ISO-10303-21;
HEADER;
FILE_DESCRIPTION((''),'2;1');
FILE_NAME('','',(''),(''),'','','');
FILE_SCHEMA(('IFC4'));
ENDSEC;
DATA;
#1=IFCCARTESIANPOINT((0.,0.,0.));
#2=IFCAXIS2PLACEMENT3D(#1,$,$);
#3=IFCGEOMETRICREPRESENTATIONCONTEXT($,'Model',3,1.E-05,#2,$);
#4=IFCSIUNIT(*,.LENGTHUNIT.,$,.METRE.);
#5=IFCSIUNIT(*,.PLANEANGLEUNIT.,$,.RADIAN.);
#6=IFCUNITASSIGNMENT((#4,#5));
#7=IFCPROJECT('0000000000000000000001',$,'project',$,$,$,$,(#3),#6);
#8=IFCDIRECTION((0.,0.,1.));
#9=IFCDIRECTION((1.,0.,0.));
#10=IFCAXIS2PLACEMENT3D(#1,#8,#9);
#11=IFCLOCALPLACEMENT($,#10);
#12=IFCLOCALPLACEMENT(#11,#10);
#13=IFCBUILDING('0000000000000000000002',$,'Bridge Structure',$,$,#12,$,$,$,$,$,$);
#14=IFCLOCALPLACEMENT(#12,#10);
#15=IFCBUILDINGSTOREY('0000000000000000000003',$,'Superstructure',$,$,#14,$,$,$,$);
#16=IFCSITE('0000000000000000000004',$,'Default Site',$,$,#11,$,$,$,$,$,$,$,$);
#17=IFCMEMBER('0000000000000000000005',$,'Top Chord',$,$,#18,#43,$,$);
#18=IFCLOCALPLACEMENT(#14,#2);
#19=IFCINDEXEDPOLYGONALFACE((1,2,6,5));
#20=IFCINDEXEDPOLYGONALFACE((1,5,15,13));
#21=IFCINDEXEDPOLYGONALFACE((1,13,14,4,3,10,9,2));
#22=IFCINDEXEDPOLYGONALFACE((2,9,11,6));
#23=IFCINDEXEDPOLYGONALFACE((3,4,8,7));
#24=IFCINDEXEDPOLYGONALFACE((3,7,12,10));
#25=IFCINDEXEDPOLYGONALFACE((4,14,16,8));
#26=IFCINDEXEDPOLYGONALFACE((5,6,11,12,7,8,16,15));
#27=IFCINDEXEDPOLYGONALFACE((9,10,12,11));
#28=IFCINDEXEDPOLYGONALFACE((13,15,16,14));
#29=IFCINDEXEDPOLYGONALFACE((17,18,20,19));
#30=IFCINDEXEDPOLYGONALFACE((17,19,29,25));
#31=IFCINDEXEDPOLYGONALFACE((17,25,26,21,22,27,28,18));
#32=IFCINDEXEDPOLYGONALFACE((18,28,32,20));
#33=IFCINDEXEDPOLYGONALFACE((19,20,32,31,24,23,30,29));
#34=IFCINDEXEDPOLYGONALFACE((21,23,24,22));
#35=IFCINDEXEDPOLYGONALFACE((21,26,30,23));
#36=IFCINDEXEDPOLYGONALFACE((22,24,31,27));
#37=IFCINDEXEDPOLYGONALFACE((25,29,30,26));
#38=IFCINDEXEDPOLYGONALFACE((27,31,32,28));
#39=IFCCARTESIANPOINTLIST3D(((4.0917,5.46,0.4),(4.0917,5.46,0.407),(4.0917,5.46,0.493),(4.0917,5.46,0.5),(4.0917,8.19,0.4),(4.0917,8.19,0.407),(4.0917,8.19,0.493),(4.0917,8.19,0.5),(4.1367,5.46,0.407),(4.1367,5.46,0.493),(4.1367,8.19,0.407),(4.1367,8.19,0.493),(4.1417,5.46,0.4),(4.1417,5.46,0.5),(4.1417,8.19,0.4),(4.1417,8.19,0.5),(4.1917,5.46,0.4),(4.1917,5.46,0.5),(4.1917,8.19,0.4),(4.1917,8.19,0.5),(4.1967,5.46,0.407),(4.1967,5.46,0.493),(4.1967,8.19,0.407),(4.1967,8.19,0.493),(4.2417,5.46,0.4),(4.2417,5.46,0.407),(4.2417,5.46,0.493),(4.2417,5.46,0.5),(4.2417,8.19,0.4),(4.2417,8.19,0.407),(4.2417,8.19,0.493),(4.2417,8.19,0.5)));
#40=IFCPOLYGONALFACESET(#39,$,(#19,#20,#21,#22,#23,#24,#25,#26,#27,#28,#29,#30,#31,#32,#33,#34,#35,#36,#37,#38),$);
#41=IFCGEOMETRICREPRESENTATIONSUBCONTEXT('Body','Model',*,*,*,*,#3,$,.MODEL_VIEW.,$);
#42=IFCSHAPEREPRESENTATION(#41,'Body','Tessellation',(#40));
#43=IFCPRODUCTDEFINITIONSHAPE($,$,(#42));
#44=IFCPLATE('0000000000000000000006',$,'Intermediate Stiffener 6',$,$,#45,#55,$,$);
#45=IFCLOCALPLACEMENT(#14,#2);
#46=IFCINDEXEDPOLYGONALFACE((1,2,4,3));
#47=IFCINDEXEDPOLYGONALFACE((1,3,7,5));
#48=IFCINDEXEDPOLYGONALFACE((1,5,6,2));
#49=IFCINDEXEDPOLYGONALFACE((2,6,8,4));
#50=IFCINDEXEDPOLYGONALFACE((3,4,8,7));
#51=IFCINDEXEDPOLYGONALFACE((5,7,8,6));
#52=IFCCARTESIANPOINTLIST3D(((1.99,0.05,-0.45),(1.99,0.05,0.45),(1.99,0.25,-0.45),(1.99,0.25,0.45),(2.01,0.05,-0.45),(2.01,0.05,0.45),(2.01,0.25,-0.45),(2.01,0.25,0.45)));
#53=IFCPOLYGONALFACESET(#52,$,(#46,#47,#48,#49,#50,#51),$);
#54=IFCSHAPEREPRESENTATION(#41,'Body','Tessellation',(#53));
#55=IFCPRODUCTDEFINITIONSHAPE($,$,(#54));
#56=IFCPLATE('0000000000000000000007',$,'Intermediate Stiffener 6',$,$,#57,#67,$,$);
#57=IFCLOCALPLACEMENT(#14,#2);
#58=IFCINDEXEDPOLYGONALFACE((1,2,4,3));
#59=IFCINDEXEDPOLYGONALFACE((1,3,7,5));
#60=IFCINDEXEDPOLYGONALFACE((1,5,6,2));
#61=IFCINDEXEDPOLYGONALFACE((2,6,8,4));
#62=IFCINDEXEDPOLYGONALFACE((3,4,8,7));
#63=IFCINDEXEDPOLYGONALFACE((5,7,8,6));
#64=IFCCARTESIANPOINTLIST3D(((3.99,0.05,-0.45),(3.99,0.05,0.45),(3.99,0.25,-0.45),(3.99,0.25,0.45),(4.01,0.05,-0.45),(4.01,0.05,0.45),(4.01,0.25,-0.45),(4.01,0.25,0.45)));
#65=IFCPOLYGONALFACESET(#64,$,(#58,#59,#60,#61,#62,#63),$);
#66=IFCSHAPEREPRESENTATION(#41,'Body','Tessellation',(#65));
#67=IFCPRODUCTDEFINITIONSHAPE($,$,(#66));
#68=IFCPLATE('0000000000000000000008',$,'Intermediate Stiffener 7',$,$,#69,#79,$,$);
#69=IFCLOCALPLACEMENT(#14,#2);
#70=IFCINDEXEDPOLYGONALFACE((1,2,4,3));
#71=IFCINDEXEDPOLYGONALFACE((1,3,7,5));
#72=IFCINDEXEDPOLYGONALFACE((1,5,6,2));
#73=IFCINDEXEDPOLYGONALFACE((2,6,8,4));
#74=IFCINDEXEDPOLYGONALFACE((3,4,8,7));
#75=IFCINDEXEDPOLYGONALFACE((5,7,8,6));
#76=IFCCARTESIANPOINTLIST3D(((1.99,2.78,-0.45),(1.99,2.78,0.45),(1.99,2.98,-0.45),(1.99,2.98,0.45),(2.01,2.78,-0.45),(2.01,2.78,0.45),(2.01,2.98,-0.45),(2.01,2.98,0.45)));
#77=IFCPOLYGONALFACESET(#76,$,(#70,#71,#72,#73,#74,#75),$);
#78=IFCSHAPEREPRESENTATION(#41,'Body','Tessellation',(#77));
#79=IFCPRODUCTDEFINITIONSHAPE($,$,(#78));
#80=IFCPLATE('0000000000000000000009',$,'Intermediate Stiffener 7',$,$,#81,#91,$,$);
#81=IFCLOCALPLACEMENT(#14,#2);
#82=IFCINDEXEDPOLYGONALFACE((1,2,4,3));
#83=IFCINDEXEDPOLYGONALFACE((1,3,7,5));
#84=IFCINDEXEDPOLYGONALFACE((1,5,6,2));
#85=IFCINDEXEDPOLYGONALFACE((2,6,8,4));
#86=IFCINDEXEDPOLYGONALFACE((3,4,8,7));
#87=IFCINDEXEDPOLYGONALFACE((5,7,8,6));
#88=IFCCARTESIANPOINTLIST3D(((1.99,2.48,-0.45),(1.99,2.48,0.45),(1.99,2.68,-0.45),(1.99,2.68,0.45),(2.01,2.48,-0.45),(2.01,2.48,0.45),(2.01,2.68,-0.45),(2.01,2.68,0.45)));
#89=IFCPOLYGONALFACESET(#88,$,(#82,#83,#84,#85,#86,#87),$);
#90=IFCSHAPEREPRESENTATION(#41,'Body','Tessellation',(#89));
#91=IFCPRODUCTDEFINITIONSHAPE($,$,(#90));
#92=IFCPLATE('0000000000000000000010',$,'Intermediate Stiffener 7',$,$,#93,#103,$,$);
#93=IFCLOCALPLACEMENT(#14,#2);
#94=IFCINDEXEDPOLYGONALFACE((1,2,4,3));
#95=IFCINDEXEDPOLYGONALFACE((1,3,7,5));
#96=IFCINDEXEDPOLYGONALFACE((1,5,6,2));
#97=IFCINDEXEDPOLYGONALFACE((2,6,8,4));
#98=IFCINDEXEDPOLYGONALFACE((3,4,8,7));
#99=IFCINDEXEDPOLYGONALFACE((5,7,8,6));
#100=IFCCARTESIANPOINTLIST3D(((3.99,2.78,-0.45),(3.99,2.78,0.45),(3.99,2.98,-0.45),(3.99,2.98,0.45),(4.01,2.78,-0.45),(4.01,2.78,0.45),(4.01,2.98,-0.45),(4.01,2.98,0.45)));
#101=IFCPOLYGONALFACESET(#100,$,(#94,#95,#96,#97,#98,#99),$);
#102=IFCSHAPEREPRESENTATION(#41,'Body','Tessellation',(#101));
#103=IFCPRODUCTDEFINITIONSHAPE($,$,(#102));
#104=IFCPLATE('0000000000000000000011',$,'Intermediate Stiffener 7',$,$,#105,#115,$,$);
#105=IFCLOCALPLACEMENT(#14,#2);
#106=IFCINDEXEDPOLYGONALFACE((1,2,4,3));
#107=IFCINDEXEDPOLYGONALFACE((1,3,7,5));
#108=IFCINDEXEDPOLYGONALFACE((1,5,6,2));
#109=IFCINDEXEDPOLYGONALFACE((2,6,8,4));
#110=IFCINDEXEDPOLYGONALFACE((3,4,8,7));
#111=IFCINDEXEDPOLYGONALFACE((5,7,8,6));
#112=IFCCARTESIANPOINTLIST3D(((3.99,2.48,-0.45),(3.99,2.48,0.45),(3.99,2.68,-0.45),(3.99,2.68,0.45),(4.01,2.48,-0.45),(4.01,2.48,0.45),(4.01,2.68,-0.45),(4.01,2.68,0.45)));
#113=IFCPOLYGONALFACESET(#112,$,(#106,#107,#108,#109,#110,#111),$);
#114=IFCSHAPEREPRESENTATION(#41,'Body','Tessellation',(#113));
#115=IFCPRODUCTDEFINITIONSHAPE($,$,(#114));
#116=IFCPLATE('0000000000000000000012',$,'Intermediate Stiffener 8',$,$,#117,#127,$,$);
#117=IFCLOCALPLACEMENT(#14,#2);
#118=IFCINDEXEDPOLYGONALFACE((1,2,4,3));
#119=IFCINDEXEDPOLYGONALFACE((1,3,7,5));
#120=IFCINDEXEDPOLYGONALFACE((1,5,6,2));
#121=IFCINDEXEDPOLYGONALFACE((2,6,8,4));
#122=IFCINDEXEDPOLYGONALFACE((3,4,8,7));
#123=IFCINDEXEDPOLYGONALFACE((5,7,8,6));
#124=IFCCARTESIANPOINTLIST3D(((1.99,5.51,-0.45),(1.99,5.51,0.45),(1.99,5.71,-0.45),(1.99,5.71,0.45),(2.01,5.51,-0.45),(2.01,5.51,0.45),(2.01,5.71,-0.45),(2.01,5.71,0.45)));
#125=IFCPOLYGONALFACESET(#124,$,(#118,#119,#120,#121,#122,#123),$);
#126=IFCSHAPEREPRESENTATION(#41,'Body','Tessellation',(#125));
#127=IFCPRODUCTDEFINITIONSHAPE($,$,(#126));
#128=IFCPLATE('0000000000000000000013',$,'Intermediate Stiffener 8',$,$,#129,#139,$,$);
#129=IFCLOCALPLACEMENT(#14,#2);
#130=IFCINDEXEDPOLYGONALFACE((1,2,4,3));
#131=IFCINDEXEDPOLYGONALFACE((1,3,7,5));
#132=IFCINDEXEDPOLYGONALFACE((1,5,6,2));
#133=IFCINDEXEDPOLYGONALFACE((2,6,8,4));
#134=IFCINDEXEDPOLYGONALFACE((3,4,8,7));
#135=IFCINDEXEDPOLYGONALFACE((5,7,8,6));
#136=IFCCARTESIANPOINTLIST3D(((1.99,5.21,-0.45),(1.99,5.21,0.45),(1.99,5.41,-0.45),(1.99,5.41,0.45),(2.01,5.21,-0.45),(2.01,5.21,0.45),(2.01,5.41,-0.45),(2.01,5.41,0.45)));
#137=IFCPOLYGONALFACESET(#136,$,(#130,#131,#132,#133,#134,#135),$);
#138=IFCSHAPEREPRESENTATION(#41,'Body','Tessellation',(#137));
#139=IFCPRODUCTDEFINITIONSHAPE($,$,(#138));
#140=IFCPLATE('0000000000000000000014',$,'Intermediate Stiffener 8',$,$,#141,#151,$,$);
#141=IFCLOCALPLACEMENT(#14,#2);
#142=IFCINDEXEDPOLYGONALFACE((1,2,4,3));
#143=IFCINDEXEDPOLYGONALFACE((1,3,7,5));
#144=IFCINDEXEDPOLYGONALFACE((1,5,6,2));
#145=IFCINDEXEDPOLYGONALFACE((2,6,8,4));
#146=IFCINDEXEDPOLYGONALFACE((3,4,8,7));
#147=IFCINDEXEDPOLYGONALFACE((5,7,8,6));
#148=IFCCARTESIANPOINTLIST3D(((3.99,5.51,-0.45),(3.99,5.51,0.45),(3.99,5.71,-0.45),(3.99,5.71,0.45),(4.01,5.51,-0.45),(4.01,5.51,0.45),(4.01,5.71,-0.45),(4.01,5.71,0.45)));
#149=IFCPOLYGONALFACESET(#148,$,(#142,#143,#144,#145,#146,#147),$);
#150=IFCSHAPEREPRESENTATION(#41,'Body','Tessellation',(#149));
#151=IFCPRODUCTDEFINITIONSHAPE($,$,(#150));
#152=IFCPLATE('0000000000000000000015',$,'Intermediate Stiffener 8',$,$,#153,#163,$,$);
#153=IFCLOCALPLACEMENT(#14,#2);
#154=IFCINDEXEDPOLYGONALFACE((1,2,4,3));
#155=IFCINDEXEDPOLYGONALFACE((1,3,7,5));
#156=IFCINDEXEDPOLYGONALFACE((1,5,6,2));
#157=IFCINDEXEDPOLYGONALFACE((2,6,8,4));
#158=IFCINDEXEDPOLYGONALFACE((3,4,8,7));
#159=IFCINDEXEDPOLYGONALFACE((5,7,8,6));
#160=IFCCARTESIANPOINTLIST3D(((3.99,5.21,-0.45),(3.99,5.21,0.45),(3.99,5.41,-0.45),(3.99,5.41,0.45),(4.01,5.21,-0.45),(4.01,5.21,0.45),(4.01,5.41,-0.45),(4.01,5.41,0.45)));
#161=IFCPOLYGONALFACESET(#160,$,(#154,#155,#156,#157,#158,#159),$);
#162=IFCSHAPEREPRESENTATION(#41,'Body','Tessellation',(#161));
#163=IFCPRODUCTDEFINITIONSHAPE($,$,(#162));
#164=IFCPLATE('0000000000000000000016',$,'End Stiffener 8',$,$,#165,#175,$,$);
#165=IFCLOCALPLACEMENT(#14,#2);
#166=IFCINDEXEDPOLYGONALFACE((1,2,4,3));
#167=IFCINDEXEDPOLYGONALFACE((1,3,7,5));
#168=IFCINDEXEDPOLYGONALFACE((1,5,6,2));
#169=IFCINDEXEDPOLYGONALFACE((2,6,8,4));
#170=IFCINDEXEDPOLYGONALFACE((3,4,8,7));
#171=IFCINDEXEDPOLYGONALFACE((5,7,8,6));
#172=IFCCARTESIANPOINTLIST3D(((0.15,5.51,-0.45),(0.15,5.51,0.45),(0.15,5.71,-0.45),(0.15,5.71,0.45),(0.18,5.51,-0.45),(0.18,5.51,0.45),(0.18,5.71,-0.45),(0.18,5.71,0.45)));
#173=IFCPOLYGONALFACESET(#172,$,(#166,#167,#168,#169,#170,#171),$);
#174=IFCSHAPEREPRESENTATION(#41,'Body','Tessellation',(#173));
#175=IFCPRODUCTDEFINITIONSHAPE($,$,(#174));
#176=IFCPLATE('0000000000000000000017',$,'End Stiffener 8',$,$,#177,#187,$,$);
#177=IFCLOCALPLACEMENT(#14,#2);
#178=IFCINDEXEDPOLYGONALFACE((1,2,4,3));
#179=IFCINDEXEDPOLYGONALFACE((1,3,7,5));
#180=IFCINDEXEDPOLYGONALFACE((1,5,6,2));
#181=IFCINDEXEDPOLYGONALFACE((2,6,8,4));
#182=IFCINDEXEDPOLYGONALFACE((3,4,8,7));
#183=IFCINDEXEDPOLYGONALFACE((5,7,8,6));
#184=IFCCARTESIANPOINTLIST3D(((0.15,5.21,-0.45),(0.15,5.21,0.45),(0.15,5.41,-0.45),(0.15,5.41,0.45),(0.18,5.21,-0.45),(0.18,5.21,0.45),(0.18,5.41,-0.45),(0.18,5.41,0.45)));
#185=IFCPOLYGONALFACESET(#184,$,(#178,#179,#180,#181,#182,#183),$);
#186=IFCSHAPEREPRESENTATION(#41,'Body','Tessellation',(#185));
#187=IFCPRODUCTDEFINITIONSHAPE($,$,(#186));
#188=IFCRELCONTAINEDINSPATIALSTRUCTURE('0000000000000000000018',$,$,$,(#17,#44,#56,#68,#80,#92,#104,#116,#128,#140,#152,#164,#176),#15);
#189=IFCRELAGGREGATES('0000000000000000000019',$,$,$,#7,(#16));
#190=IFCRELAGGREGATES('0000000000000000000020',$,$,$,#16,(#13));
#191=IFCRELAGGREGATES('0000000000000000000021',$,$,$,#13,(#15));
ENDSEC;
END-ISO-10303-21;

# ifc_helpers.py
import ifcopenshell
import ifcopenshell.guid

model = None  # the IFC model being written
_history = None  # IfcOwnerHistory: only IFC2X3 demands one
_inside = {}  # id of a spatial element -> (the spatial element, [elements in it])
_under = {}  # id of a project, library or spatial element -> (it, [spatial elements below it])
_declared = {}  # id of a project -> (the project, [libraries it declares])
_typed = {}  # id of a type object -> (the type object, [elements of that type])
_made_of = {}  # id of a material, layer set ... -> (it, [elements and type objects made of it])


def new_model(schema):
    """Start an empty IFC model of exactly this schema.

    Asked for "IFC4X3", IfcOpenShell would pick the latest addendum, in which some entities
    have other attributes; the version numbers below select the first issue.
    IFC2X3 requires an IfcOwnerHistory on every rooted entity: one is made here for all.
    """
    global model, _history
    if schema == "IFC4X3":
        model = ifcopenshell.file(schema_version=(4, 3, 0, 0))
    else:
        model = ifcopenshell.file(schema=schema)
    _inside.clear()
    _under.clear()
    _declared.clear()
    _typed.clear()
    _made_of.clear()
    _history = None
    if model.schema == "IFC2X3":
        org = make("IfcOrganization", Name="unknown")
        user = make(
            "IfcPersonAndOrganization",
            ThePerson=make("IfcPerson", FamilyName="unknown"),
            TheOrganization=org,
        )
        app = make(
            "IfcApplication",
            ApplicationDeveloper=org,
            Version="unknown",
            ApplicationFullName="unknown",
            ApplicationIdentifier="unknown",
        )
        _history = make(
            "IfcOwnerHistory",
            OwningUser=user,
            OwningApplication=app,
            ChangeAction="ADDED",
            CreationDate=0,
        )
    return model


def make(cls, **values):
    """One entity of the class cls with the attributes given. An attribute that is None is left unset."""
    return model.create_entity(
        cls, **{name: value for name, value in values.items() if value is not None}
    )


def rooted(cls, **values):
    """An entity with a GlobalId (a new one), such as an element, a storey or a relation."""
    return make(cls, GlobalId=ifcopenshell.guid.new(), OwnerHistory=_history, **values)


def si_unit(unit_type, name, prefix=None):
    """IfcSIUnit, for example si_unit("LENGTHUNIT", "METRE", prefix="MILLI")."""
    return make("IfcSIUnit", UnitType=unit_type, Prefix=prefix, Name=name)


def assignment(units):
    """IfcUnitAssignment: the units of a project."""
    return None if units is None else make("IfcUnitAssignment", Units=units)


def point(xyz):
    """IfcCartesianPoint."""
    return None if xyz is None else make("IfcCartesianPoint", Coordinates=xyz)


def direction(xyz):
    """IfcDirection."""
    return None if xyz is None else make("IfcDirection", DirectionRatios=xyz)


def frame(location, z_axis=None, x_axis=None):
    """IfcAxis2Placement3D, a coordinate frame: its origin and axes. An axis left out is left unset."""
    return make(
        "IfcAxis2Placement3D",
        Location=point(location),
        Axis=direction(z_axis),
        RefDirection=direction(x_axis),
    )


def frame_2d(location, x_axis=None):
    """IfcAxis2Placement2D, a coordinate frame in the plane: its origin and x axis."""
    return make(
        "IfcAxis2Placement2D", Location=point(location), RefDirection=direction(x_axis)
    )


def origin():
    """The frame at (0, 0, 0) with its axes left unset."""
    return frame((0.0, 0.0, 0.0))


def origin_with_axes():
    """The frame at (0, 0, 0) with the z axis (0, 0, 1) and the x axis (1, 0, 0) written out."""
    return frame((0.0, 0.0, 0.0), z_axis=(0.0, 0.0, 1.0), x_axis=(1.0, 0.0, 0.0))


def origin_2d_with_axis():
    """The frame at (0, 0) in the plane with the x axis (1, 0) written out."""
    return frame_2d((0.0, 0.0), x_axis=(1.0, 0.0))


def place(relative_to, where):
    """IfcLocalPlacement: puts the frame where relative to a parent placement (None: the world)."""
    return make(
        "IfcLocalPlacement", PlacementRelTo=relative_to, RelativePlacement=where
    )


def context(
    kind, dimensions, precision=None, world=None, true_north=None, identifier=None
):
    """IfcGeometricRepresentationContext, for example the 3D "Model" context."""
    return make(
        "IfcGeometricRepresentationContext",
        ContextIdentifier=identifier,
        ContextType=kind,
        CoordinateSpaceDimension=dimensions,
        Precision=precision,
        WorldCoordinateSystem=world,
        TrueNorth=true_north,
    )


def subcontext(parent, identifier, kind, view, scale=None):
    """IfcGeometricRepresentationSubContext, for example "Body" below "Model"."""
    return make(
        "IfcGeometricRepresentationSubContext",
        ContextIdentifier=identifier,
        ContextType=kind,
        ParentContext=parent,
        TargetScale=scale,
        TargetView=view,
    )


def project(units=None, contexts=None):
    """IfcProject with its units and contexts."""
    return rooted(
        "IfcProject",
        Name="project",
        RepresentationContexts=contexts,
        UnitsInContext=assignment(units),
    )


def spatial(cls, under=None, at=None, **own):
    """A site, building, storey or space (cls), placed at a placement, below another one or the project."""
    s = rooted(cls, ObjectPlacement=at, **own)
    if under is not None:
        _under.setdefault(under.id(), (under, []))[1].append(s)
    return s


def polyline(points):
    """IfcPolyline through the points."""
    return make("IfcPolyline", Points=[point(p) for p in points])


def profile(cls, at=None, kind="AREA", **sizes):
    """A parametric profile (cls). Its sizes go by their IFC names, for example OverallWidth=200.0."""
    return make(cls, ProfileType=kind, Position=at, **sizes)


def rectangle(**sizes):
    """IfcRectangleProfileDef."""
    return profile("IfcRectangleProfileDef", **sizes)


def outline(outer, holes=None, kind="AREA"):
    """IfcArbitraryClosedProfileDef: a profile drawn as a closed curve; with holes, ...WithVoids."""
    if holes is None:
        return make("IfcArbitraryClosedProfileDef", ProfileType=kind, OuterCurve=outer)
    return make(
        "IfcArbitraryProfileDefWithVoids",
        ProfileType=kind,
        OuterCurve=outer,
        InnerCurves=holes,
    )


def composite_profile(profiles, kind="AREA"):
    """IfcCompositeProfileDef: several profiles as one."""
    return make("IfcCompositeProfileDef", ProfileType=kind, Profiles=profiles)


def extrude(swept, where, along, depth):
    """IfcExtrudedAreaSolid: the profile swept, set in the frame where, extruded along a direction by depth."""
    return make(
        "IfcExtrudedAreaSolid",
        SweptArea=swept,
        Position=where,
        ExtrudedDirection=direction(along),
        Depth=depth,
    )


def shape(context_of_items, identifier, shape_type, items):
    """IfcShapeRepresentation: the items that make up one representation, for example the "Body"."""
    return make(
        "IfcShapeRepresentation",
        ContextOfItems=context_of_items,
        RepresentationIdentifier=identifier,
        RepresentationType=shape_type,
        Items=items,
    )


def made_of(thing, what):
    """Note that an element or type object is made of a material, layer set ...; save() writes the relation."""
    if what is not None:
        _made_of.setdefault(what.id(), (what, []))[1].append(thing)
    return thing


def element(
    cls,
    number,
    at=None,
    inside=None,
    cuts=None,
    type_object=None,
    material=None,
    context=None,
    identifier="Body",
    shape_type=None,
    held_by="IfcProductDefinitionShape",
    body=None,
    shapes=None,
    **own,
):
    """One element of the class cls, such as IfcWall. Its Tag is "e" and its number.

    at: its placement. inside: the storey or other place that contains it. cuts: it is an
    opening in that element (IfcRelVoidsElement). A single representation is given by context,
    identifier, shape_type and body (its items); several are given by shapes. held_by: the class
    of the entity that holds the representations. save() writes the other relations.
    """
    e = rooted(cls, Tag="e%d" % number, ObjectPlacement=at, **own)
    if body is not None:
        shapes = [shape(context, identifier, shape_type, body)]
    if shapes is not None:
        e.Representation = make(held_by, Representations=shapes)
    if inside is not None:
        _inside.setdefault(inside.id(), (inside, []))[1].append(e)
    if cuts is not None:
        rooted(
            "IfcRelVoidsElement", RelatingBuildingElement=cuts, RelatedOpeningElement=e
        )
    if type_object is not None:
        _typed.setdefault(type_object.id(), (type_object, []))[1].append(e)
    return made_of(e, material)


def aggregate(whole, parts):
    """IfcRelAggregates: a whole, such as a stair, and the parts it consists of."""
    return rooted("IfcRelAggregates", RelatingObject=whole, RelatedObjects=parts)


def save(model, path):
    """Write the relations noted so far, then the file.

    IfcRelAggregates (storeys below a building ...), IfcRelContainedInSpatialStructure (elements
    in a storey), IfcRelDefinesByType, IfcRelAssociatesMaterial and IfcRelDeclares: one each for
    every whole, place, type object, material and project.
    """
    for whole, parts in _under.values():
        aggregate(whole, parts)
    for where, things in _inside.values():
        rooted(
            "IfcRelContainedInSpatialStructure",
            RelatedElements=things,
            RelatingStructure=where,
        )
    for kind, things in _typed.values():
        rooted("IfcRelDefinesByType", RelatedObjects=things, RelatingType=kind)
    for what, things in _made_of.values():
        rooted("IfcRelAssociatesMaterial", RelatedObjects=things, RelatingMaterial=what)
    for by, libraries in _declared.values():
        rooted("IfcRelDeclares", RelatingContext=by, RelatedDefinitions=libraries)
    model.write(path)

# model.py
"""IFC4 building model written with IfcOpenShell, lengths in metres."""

from ifc_helpers import new_model, si_unit, frame, origin, origin_with_axes, origin_2d_with_axis, place, context, subcontext, project, spatial, polyline, rectangle, outline, composite_profile, extrude, element, save


model = new_model("IFC4")

# Units and contexts
model_context = context("Model", 3, precision=1e-05, world=origin())
body_context = subcontext(model_context, "Body", "Model", "MODEL_VIEW")
ifc_project = project(units=[si_unit("LENGTHUNIT", "METRE"), si_unit("PLANEANGLEUNIT", "RADIAN")], contexts=[model_context])

# Site, building, storey
site_placement = place(None, origin_with_axes())
site = spatial("IfcSite", under=ifc_project, at=site_placement, Name="Default Site")
building_placement = place(site_placement, origin_with_axes())
building = spatial("IfcBuilding", under=site, at=building_placement, Name="Bridge Structure")
storey_placement = place(building_placement, origin_with_axes())
storey = spatial("IfcBuildingStorey", under=building, at=storey_placement, Name="Superstructure")

# Member
member_1_placement = place(storey_placement, frame((4.1667, 5.46, 0.45), z_axis=(0.0, 1.0, 0.0), x_axis=(-1.0, 0.0, 0.0)))
element("IfcMember", 1, at=member_1_placement, inside=storey, Name="Top Chord", context=body_context, shape_type="SweptSolid", body=[
    extrude(composite_profile([outline(polyline([(-0.025, -0.05), (-0.025, 0.05), (-0.075, 0.05), (-0.075, 0.043), (-0.03, 0.043), (-0.03, -0.043), (-0.075, -0.043), (-0.075, -0.05), (-0.025, -0.05)])), outline(polyline([(0.025, -0.05), (0.075, -0.05), (0.075, -0.043), (0.03, -0.043), (0.03, 0.043), (0.075, 0.043), (0.075, 0.05), (0.025, 0.05), (0.025, -0.05)]))]), origin_with_axes(), (0.0, 0.0, 1.0), 2.73),
])

# Plates
for number, where, z_axis, x_axis, name in (
    (2, (2.0, 0.15, -0.45), (0.0, 0.0, 1.0), (1.0, 0.0, 0.0), "Intermediate Stiffener 6"),
    (3, (4.0, 0.15, -0.45), (0.0, 0.0, 1.0), (1.0, 0.0, 0.0), "Intermediate Stiffener 6"),
    (4, (2.0, 2.88, -0.45), (0.0, 0.0, 1.0), (1.0, 0.0, 0.0), "Intermediate Stiffener 7"),
    (5, (2.0, 2.58, -0.45), (0.0, 0.0, 1.0), (1.0, 0.0, 0.0), "Intermediate Stiffener 7"),
    (6, (4.0, 2.88, -0.45), (0.0, 0.0, 1.0), (1.0, 0.0, 0.0), "Intermediate Stiffener 7"),
    (7, (4.0, 2.58, -0.45), (0.0, 0.0, 1.0), (1.0, 0.0, 0.0), "Intermediate Stiffener 7"),
    (8, (2.0, 5.61, -0.45), (0.0, 0.0, 1.0), (1.0, 0.0, 0.0), "Intermediate Stiffener 8"),
    (9, (2.0, 5.31, -0.45), (0.0, 0.0, 1.0), (1.0, 0.0, 0.0), "Intermediate Stiffener 8"),
    (10, (4.0, 5.61, -0.45), (0.0, 0.0, 1.0), (1.0, 0.0, 0.0), "Intermediate Stiffener 8"),
    (11, (4.0, 5.31, -0.45), (0.0, 0.0, 1.0), (1.0, 0.0, 0.0), "Intermediate Stiffener 8"),
):
    element("IfcPlate", number, at=place(storey_placement, frame(where, z_axis=z_axis, x_axis=x_axis)), inside=storey, Name=name, context=body_context, shape_type="SweptSolid", body=[
        extrude(rectangle(XDim=0.02, YDim=0.2, at=origin_2d_with_axis()), origin_with_axes(), (0.0, 0.0, 1.0), 0.9),
    ])
for number, where, z_axis, x_axis, name in (
    (12, (0.165, 5.61, -0.45), (0.0, 0.0, 1.0), (1.0, 0.0, 0.0), "End Stiffener 8"),
    (13, (0.165, 5.31, -0.45), (0.0, 0.0, 1.0), (1.0, 0.0, 0.0), "End Stiffener 8"),
):
    element("IfcPlate", number, at=place(storey_placement, frame(where, z_axis=z_axis, x_axis=x_axis)), inside=storey, Name=name, context=body_context, shape_type="SweptSolid", body=[
        extrude(rectangle(XDim=0.03, YDim=0.2, at=origin_2d_with_axis()), origin_with_axes(), (0.0, 0.0, 1.0), 0.9),
    ])

save(model, "model.ifc")
